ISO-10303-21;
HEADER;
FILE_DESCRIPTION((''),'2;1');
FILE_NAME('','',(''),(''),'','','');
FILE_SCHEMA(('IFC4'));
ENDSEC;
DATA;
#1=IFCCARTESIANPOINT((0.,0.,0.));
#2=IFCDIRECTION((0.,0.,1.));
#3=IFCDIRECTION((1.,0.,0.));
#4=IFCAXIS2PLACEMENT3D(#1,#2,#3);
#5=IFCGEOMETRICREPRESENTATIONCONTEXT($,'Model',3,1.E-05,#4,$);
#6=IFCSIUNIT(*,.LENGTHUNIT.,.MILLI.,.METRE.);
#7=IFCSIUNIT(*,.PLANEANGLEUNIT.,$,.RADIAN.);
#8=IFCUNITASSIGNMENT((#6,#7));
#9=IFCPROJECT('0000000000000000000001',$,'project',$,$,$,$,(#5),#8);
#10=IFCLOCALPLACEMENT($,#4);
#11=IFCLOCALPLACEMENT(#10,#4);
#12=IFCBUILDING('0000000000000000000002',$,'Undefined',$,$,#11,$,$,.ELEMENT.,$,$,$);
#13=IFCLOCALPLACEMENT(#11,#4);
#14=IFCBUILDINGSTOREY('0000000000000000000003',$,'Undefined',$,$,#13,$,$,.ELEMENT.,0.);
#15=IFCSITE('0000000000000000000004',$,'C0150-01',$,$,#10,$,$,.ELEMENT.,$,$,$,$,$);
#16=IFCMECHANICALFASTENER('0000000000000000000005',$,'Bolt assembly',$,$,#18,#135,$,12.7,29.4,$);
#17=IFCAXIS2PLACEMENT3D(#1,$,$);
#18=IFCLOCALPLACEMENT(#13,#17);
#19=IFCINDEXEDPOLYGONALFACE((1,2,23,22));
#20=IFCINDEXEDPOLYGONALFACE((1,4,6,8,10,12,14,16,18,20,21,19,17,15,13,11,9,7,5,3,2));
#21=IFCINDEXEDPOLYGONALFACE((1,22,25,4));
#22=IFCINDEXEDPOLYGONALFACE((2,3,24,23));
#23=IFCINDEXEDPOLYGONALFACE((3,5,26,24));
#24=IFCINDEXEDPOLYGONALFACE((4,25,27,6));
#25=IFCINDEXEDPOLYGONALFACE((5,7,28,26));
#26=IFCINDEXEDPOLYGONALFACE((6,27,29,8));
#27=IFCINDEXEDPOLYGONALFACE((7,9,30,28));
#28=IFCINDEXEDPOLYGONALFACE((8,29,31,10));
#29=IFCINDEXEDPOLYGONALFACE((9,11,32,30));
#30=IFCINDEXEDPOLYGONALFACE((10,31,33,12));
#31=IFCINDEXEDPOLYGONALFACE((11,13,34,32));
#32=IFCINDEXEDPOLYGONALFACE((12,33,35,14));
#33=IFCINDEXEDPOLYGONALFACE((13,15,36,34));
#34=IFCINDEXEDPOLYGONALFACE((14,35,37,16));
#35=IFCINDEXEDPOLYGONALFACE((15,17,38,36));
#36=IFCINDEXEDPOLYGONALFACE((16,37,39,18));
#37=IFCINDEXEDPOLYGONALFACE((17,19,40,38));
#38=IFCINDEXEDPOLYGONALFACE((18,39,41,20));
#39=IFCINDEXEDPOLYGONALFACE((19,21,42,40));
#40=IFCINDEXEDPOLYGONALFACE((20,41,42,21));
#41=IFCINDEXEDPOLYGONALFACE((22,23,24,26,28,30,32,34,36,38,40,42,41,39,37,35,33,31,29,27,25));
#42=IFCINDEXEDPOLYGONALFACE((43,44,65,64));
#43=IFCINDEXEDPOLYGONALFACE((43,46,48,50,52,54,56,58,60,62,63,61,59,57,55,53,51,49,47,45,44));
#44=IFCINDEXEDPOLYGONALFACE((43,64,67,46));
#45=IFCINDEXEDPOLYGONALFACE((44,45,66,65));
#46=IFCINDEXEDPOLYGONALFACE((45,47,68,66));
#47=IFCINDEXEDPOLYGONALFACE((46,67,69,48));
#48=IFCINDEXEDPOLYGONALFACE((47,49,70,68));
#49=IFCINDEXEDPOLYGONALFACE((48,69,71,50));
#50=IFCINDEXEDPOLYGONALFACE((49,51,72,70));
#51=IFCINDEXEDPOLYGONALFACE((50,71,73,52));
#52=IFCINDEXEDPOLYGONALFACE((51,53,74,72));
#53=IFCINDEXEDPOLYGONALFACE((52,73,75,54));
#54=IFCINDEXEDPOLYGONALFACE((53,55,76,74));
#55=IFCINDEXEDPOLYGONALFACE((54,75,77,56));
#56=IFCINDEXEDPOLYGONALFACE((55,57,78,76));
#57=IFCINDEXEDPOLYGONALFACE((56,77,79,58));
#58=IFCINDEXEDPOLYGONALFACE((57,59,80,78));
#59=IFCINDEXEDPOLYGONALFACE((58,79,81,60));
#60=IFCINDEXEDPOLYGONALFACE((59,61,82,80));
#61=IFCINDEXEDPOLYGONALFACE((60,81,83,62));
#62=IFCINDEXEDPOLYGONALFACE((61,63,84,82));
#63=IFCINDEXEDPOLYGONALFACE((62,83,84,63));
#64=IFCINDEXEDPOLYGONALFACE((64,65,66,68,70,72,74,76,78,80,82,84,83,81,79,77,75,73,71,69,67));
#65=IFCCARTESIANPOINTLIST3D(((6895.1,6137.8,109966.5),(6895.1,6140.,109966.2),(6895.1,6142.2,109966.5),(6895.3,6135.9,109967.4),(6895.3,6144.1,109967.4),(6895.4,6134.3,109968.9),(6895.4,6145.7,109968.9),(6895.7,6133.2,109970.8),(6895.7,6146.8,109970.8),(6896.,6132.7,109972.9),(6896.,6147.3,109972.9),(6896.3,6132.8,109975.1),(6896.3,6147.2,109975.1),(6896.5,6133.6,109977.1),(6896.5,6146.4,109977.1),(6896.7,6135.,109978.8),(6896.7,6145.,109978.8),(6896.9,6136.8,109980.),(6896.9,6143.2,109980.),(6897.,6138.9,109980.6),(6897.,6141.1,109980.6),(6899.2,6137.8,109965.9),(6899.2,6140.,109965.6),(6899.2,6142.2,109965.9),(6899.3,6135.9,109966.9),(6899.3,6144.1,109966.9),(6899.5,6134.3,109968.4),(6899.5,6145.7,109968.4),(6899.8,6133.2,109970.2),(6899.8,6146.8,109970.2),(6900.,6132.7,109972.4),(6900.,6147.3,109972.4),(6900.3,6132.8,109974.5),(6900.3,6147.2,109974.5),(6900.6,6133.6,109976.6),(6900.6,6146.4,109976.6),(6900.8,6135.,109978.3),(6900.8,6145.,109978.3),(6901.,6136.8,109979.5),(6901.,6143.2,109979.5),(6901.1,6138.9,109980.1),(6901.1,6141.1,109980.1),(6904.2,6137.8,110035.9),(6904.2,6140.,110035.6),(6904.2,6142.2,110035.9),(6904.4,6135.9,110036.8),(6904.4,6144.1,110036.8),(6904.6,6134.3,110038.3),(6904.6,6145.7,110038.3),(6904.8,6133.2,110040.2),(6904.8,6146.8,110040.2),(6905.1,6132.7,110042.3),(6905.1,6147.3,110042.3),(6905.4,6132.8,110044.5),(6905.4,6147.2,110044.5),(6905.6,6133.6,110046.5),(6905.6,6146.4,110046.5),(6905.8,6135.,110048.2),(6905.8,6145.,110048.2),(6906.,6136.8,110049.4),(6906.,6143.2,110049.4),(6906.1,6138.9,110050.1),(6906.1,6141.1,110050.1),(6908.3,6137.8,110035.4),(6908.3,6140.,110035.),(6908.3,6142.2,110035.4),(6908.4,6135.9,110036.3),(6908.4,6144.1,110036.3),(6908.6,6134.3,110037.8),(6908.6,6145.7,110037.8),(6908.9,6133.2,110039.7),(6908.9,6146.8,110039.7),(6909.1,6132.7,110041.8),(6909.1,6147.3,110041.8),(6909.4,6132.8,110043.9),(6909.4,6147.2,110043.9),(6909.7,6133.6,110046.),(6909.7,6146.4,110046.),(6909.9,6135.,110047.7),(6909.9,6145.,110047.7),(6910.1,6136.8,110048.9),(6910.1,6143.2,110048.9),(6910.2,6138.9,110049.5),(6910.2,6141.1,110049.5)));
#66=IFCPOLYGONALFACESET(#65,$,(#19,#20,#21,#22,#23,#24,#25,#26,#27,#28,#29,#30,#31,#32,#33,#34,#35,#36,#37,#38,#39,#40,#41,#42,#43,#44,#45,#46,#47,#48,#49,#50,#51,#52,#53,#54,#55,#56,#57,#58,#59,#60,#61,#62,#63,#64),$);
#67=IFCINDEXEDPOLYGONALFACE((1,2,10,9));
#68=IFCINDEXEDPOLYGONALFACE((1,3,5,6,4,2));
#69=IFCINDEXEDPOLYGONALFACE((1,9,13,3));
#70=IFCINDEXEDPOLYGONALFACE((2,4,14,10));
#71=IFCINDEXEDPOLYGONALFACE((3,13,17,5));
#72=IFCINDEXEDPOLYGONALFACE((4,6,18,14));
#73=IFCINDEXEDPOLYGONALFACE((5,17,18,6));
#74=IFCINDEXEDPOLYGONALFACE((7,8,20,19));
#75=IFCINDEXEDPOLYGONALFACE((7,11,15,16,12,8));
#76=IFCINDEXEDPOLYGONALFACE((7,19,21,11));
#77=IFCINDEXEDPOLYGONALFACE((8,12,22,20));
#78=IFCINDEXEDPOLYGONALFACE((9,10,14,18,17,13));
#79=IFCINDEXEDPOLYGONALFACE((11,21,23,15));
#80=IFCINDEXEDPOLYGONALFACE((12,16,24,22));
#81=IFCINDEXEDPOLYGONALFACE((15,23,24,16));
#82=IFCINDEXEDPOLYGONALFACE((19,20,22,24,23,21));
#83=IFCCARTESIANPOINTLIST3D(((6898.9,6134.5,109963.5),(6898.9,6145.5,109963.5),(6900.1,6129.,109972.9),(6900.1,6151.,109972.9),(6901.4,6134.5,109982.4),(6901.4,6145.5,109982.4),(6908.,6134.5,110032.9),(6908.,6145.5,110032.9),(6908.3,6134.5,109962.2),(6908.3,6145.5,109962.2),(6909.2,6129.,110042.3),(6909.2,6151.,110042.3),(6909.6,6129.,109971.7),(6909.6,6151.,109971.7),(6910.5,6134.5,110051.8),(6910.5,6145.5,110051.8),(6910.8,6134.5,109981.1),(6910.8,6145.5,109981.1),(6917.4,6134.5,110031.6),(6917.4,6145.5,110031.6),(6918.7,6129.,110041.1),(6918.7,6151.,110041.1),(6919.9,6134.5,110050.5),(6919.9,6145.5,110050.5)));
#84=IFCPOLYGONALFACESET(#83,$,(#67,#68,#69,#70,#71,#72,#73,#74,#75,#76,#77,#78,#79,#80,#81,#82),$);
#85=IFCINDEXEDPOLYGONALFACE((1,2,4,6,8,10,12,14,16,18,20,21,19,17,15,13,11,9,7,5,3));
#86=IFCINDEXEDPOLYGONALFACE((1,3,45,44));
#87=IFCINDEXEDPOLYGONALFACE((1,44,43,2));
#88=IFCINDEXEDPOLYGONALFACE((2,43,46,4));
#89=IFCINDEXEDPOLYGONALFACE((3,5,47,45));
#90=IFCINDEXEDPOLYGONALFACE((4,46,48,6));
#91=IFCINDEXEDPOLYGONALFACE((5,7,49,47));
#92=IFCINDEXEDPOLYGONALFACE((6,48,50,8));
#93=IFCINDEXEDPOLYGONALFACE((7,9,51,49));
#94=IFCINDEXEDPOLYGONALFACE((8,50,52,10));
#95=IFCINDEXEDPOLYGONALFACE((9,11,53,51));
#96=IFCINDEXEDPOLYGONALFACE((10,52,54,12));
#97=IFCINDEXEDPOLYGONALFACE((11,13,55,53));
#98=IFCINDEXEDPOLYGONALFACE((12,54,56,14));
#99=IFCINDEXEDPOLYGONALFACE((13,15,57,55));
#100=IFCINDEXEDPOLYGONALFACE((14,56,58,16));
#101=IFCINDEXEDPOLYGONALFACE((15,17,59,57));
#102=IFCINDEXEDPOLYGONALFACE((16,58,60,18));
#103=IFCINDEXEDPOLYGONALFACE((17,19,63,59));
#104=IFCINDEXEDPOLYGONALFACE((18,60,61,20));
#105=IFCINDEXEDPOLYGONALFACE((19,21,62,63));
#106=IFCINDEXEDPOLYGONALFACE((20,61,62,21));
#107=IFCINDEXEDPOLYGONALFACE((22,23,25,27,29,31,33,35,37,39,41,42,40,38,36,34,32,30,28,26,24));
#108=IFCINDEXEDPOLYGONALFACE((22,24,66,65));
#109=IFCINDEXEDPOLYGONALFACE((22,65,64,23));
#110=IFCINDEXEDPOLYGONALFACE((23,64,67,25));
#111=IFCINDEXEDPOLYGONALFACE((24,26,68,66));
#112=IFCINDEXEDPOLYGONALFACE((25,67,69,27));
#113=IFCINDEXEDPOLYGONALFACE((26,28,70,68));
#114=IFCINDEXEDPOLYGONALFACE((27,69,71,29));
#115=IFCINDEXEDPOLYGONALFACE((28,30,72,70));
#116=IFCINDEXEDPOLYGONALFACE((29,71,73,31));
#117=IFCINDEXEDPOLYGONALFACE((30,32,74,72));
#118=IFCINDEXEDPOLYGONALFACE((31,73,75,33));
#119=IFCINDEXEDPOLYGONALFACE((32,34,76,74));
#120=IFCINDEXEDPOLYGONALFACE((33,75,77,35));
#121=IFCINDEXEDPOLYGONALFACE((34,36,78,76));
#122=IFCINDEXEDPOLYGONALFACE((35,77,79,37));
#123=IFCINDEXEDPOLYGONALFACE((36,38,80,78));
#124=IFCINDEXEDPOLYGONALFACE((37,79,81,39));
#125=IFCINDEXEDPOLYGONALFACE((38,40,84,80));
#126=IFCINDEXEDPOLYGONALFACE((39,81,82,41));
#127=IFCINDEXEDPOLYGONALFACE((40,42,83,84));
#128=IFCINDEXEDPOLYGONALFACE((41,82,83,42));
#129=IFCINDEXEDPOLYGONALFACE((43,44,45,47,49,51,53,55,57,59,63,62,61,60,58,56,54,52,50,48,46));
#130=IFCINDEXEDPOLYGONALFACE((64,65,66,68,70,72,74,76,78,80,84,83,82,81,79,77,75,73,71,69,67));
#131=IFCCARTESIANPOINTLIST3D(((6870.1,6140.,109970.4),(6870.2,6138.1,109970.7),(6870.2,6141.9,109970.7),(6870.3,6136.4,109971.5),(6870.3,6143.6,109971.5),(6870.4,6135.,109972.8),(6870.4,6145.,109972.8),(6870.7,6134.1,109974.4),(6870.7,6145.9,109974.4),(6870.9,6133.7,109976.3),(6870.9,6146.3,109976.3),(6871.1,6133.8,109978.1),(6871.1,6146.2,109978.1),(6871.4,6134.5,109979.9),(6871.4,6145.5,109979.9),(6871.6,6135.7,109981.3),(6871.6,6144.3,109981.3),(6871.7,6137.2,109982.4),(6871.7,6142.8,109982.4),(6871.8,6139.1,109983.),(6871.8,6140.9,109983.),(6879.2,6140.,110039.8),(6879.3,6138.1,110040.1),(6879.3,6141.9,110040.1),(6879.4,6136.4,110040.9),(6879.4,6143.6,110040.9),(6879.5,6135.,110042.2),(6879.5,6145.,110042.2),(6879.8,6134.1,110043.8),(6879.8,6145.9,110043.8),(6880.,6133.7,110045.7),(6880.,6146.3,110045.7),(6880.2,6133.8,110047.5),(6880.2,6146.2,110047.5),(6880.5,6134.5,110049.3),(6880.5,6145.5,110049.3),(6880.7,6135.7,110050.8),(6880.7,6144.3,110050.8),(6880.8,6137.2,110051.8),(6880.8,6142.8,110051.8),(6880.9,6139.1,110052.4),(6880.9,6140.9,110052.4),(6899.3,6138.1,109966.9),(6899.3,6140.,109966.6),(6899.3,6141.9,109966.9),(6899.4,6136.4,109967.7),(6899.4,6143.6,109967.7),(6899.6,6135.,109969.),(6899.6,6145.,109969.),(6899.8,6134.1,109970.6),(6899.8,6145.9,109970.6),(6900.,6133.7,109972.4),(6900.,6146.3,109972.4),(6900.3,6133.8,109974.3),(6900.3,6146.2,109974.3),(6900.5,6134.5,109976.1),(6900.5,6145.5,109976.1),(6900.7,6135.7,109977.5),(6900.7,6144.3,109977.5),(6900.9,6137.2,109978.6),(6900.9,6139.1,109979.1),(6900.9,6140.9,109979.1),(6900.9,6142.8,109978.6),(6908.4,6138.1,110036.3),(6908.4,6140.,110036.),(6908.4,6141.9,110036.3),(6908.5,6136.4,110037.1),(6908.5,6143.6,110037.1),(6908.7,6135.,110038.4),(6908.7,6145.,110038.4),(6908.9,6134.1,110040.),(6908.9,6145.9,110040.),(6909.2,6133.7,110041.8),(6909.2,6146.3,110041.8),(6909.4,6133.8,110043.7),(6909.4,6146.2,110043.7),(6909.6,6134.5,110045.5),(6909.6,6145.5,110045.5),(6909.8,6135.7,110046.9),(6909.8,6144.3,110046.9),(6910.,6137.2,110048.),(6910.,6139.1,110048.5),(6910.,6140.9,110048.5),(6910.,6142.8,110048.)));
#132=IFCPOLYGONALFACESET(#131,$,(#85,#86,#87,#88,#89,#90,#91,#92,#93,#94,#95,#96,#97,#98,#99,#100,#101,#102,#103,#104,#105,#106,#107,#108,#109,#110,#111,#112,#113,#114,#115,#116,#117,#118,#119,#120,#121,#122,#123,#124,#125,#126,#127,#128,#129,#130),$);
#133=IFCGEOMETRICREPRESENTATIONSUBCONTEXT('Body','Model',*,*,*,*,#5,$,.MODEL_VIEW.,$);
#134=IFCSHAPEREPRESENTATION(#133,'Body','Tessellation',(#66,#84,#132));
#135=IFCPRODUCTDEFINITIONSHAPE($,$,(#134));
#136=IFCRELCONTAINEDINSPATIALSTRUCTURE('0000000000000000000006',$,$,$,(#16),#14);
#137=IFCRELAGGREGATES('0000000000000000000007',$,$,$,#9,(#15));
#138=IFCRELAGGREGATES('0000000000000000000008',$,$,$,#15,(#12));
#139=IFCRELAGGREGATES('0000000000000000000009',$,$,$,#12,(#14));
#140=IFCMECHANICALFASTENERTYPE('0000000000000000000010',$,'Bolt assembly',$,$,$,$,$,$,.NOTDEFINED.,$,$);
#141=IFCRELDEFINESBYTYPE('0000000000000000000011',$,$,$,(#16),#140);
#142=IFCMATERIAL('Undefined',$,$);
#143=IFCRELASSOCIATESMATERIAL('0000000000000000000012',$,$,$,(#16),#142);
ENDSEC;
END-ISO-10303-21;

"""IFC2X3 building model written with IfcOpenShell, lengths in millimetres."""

from ifc_helpers import new_model, si_unit, frame, origin_with_axes, origin_2d_with_axis, place, context, subcontext, project, spatial, polyline, circle, outline, extrude, source, transform, mapped, material, type_object, element, save


model = new_model("IFC2X3")

# Units and contexts
model_context = context("Model", 3, precision=1e-05, world=origin_with_axes())
body_context = subcontext(model_context, "Body", "Model", "MODEL_VIEW")
ifc_project = project(units=[si_unit("LENGTHUNIT", "METRE", prefix="MILLI"), si_unit("PLANEANGLEUNIT", "RADIAN")], contexts=[model_context])

# Site, building, storey
site_placement = place(None, origin_with_axes())
site = spatial("IfcSite", under=ifc_project, at=site_placement, Name="C0150-01", CompositionType="ELEMENT")
building_placement = place(site_placement, origin_with_axes())
building = spatial("IfcBuilding", under=site, at=building_placement, Name="Undefined", CompositionType="ELEMENT")
storey_placement = place(building_placement, origin_with_axes())
storey = spatial("IfcBuildingStorey", under=building, at=storey_placement, Name="Undefined", CompositionType="ELEMENT", Elevation=0.0)

# Mechanical fastener
ifc_material_1 = material(Name="Undefined")
mechanical_fastener_type = type_object("IfcMechanicalFastenerType", Name="Bolt assembly")
shared_shape_1 = source(origin_with_axes(), body_context, "Body", "SweptSolid", [
    extrude(circle(Radius=7.3, at=origin_2d_with_axis()), frame((0.0, 0.0, 0.0), z_axis=(0.0, 1.0, 0.0), x_axis=(1.0, 0.0, 0.0)), (0.0, 0.0, 1.0), 4.1),
    extrude(outline(polyline([(9.5, -5.5), (9.5, 5.5), (0.0, 11.0), (-9.5, 5.5), (-9.5, -5.5), (0.0, -11.0), (9.5, -5.5)])), frame((0.0, -9.5, 0.0), z_axis=(0.0, 1.0, 0.0), x_axis=(1.0, 0.0, 0.0)), (0.0, 0.0, 1.0), 9.5),
    extrude(circle(Radius=6.3, at=origin_2d_with_axis()), frame((0.0, 0.0, 0.0), z_axis=(0.0, 1.0, 0.0), x_axis=(1.0, 0.0, 0.0)), (0.0, 0.0, 1.0), 29.4),
])
for number, where, z_axis, x_axis, name in (
    (1, (6909.2, 6140.0, 110042.3), (0.0, 1.0, 0.0), (-0.130054, 0.0, -0.991507), "Bolt assembly"),
):
    element("IfcMechanicalFastener", number, at=place(storey_placement, frame(where, z_axis=z_axis, x_axis=x_axis)), inside=storey, type_object=mechanical_fastener_type, material=ifc_material_1, Name=name, NominalDiameter=12.7, NominalLength=29.4, context=body_context, shape_type="MappedRepresentation", body=[
        mapped(shared_shape_1, transform((0.0, 0.0, 0.0))),
        mapped(shared_shape_1, transform((70.0, 0.0, 0.0))),
    ])

save(model, "model.ifc")
